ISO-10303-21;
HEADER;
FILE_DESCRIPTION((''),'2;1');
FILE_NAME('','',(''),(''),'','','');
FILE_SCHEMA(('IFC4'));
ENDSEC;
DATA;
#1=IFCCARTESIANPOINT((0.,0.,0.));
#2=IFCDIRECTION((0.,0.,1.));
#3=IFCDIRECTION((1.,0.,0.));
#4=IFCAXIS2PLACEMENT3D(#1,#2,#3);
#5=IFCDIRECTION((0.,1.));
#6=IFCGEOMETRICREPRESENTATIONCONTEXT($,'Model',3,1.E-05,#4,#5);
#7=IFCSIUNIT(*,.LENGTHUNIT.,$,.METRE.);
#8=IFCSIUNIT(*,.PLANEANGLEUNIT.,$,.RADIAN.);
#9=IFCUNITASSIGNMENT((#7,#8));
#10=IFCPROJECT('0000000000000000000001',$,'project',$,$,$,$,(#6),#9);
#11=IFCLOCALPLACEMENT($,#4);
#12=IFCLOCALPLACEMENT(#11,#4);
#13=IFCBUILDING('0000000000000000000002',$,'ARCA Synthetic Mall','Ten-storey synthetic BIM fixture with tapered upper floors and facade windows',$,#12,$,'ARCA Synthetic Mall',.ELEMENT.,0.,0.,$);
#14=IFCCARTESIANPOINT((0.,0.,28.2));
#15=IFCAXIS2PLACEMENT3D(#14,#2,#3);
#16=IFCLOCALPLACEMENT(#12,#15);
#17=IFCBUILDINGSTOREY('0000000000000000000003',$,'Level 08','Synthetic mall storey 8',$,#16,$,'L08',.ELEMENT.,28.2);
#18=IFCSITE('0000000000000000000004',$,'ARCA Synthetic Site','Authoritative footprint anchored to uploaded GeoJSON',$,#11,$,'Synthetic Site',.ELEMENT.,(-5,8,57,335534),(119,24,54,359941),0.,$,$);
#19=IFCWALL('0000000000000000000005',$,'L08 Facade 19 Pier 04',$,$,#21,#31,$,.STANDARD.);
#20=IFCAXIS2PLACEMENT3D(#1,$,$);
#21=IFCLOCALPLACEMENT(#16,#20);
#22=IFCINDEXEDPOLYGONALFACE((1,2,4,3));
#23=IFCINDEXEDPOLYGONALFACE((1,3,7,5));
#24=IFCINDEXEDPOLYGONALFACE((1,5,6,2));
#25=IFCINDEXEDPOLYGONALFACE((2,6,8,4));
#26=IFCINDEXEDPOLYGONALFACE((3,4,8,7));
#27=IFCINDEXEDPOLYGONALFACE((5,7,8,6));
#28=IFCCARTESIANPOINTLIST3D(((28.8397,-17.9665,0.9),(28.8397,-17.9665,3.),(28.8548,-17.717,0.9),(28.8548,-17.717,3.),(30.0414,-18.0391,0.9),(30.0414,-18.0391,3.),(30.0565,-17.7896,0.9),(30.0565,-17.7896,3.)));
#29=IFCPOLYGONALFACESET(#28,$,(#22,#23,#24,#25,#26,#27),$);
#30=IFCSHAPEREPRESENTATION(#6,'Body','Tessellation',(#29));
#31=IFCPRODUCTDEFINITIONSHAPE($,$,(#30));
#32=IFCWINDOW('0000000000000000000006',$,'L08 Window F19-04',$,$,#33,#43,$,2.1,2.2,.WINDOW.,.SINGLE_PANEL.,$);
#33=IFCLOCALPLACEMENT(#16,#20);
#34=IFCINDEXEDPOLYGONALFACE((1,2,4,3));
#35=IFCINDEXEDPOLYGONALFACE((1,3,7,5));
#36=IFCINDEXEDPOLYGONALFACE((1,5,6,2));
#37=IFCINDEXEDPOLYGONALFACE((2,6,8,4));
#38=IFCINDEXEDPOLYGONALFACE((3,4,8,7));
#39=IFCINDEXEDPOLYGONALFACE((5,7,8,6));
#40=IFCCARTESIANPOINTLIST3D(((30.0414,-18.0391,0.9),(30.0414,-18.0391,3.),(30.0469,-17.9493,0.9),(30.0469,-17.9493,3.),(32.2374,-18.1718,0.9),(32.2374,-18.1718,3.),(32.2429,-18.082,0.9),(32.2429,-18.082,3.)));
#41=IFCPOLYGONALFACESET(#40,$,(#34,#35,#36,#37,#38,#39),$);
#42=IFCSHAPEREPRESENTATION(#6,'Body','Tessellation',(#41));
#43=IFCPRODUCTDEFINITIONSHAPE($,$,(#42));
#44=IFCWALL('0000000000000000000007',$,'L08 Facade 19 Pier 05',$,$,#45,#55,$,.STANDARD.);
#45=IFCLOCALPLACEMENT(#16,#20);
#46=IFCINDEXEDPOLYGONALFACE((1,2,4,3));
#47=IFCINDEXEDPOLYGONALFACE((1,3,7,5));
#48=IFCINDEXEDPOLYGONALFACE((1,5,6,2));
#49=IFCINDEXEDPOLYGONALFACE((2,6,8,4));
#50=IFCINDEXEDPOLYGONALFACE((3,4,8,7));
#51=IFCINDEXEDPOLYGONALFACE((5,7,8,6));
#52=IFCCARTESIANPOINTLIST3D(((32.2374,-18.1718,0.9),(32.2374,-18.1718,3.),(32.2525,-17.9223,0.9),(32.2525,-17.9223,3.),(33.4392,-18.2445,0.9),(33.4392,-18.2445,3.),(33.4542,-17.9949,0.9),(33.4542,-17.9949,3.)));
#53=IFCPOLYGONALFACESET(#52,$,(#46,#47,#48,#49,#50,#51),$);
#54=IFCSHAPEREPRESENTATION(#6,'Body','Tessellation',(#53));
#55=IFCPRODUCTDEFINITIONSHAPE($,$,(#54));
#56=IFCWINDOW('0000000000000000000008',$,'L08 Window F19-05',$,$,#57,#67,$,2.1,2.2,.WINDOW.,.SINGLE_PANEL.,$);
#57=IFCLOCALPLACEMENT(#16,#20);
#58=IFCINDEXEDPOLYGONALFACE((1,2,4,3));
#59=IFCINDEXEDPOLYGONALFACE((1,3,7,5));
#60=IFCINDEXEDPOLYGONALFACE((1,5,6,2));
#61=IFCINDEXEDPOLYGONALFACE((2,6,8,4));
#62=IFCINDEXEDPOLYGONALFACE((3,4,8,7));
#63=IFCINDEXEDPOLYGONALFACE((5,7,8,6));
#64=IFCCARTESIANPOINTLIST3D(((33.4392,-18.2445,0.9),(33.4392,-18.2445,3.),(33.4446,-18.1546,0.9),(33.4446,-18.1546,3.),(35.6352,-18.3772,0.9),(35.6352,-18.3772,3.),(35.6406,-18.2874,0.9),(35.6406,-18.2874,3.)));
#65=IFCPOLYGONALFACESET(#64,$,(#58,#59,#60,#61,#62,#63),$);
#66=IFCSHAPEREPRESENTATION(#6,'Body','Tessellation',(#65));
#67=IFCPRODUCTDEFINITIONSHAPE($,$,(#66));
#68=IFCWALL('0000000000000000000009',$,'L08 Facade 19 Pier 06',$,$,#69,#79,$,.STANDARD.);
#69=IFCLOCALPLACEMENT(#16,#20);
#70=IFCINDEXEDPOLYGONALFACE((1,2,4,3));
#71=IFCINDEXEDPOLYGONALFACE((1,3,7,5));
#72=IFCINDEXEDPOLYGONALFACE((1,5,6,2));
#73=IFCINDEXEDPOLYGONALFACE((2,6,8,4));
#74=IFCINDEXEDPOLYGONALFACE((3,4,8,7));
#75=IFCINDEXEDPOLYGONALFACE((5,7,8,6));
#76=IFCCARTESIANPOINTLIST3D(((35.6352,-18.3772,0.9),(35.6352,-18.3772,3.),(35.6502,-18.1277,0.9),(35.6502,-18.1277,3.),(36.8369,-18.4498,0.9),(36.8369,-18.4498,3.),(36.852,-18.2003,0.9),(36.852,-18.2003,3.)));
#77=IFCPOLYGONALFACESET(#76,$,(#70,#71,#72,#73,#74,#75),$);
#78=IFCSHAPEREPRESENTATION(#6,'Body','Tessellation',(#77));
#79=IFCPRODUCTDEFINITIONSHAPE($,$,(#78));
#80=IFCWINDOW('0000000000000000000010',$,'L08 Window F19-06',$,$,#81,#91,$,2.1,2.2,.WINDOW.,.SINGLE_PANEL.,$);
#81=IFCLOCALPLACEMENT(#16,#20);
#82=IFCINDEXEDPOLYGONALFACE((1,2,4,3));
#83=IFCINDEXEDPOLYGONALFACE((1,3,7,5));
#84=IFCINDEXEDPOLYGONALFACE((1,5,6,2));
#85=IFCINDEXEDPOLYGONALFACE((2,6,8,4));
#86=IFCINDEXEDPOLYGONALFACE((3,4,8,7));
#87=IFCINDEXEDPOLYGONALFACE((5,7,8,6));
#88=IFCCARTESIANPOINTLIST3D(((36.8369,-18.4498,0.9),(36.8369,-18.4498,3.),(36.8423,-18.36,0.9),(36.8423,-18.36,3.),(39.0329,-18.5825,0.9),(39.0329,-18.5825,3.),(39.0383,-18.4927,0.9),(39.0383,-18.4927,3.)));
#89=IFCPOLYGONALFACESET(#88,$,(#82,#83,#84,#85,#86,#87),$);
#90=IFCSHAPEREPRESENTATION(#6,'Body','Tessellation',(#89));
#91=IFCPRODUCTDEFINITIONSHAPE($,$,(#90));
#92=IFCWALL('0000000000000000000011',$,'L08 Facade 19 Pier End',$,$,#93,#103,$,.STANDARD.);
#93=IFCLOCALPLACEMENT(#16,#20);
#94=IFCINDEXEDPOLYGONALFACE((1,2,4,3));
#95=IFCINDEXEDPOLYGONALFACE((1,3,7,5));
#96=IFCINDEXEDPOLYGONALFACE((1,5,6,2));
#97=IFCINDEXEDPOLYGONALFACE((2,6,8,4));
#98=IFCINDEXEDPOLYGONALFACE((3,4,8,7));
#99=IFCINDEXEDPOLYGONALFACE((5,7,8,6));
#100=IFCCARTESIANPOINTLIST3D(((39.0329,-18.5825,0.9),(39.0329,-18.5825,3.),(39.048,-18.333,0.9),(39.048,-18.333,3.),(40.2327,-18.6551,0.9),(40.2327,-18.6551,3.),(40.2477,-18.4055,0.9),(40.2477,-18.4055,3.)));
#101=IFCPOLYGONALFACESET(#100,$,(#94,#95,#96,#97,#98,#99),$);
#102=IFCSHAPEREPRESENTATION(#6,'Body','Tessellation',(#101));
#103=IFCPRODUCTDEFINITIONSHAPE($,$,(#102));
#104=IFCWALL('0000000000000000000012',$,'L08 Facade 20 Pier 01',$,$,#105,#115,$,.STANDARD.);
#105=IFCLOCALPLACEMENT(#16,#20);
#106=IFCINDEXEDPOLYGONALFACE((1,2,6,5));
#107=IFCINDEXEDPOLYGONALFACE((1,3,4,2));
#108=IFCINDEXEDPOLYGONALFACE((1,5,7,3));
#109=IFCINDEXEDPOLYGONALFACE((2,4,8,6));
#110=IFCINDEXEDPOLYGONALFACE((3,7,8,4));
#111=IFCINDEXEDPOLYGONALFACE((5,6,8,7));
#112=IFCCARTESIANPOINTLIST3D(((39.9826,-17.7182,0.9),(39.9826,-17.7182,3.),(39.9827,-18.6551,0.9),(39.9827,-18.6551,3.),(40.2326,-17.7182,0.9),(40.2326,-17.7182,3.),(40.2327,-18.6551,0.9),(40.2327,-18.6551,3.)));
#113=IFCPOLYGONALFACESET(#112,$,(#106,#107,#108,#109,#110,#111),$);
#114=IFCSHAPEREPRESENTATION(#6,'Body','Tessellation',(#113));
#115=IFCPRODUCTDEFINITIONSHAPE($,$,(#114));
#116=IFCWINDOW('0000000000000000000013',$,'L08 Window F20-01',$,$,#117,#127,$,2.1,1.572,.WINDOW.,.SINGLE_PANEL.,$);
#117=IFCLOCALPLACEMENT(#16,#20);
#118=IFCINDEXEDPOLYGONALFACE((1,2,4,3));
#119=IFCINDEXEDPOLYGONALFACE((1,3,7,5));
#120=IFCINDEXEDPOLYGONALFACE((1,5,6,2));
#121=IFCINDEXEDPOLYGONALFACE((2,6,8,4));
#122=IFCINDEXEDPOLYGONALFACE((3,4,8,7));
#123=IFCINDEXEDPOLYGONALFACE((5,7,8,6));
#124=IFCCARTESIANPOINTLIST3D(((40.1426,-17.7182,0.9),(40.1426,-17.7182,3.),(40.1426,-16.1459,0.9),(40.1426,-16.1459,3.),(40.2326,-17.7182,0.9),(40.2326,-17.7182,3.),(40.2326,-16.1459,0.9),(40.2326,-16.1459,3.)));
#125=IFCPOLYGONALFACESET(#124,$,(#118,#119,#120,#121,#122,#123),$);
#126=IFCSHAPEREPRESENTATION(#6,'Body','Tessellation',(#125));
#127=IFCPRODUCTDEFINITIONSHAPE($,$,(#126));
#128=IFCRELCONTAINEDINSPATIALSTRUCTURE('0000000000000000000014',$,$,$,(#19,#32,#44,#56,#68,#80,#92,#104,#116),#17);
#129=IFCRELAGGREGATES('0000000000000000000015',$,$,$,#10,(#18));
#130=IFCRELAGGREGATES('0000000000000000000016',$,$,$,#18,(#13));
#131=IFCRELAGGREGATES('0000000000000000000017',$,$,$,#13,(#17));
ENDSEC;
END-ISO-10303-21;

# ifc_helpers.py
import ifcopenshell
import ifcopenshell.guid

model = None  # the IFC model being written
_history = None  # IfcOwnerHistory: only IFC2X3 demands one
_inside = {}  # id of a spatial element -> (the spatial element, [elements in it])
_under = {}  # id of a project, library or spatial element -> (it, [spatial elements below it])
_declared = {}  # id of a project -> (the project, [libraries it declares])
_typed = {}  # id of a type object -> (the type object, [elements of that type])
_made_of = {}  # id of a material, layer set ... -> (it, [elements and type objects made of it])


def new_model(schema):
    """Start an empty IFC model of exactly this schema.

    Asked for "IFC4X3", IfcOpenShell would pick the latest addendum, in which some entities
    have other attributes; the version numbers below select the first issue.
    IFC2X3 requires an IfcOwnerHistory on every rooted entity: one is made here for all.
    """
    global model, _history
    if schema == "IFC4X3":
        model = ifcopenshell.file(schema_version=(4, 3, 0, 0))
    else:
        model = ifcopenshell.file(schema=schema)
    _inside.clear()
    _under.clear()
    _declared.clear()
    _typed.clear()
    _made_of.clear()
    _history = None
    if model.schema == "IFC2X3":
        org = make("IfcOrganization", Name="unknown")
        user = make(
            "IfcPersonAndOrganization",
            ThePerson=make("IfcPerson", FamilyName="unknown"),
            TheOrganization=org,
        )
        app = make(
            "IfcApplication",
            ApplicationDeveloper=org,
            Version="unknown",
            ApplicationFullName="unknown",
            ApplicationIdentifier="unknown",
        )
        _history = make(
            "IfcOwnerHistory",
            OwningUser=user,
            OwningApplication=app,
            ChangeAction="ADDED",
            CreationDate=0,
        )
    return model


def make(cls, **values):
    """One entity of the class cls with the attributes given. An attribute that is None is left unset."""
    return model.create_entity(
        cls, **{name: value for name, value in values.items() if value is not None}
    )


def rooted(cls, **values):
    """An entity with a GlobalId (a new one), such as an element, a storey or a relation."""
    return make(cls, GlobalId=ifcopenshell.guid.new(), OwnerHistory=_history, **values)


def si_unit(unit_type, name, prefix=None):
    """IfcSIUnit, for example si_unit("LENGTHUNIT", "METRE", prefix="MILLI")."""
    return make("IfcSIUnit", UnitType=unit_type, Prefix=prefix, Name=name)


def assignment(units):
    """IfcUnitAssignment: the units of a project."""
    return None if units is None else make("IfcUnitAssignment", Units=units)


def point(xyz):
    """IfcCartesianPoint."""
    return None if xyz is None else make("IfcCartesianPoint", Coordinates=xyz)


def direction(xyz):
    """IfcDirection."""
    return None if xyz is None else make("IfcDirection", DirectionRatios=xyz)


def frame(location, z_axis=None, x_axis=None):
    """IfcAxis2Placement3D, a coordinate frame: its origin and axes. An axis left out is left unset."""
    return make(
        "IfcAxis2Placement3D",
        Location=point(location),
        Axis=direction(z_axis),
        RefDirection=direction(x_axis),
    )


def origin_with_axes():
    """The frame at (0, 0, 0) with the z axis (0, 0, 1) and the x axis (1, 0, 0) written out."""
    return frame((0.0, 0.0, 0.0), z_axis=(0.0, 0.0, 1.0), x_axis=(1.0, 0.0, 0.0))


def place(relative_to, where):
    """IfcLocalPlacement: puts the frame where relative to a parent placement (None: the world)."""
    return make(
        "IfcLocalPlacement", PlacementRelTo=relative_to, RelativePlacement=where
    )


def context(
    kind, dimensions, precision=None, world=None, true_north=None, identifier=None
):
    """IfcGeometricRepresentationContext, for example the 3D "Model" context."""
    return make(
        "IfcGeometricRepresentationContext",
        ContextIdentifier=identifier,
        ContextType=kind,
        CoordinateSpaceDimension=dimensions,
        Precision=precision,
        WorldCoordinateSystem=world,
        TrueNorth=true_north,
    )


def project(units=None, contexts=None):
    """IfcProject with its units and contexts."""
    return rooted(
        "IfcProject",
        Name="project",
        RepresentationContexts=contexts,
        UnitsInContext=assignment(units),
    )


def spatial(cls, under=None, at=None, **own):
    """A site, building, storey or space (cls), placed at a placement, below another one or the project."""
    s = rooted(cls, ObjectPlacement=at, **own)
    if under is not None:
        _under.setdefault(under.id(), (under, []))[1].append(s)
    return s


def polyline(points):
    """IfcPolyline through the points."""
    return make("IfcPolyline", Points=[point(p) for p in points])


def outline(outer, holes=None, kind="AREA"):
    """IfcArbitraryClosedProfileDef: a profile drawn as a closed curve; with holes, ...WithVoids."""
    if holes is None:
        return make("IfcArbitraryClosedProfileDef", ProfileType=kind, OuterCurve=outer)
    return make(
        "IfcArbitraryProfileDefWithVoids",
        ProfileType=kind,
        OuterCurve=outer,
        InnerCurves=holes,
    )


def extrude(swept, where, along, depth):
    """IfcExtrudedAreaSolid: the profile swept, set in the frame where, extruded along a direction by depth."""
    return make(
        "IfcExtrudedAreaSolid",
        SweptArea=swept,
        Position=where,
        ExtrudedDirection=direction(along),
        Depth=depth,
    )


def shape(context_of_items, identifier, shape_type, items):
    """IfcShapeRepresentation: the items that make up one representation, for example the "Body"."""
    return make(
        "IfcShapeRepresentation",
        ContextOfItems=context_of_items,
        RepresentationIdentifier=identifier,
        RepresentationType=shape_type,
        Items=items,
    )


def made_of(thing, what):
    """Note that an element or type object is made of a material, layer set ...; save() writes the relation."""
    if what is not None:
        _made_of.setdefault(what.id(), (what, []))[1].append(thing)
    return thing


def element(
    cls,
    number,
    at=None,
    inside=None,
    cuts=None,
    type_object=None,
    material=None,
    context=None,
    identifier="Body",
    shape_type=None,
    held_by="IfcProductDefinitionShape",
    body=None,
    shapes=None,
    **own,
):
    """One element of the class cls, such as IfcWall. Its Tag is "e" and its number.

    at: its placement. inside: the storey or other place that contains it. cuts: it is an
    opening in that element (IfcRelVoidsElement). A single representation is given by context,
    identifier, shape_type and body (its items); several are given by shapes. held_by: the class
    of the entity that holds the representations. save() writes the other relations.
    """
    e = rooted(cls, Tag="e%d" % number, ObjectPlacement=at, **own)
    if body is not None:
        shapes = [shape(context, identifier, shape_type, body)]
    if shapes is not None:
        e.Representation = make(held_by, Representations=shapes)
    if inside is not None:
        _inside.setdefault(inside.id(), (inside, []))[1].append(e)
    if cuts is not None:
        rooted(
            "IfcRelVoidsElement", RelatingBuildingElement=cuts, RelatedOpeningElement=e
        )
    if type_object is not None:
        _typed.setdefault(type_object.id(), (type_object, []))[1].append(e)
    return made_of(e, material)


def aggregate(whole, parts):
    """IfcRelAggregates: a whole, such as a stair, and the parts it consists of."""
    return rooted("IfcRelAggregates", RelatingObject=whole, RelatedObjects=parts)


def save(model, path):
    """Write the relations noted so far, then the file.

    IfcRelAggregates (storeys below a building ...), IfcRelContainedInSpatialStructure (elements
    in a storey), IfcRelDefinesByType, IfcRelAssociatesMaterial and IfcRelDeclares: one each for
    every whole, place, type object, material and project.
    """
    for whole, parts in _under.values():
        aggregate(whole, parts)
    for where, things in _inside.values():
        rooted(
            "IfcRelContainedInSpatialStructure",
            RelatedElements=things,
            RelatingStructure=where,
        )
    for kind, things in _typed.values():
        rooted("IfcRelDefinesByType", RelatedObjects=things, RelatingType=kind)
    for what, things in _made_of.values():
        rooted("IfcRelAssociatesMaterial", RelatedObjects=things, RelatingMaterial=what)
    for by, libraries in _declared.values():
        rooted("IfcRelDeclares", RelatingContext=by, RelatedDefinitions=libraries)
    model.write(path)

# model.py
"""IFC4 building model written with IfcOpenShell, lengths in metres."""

from ifc_helpers import new_model, si_unit, direction, frame, origin_with_axes, place, context, project, spatial, polyline, outline, extrude, element, save


model = new_model("IFC4")

# Units and contexts
model_context = context("Model", 3, precision=1e-05, world=origin_with_axes(), true_north=direction((0.0, 1.0)))
ifc_project = project(units=[si_unit("LENGTHUNIT", "METRE"), si_unit("PLANEANGLEUNIT", "RADIAN")], contexts=[model_context])

# Site, building, storey
site_placement = place(None, origin_with_axes())
site = spatial("IfcSite", under=ifc_project, at=site_placement, Name="ARCA Synthetic Site", Description="Authoritative footprint anchored to uploaded GeoJSON", LongName="Synthetic Site", CompositionType="ELEMENT", RefLatitude=(-5, 8, 57, 335534), RefLongitude=(119, 24, 54, 359941), RefElevation=0.0)
building_placement = place(site_placement, origin_with_axes())
building = spatial("IfcBuilding", under=site, at=building_placement, Name="ARCA Synthetic Mall", Description="Ten-storey synthetic BIM fixture with tapered upper floors and facade windows", LongName="ARCA Synthetic Mall", CompositionType="ELEMENT", ElevationOfRefHeight=0.0, ElevationOfTerrain=0.0)
storey_placement = place(building_placement, frame((0.0, 0.0, 28.2), z_axis=(0.0, 0.0, 1.0), x_axis=(1.0, 0.0, 0.0)))
storey = spatial("IfcBuildingStorey", under=building, at=storey_placement, Name="Level 08", Description="Synthetic mall storey 8", LongName="L08", CompositionType="ELEMENT", Elevation=28.2)

# Wall
wall_1_placement = place(storey_placement, frame((0.0, 0.0, 0.9), z_axis=(0.0, 0.0, 1.0), x_axis=(1.0, 0.0, 0.0)))
element("IfcWall", 1, at=wall_1_placement, inside=storey, Name="L08 Facade 19 Pier 04", PredefinedType="STANDARD", context=model_context, shape_type="SweptSolid", body=[
    extrude(outline(polyline([(28.8397, -17.9665), (30.0414, -18.0391), (30.0565, -17.7896), (28.8548, -17.717), (28.8397, -17.9665)])), origin_with_axes(), (0.0, 0.0, 1.0), 2.1),
])

# Window
window_1_placement = place(storey_placement, frame((0.0, 0.0, 0.9), z_axis=(0.0, 0.0, 1.0), x_axis=(1.0, 0.0, 0.0)))
element("IfcWindow", 2, at=window_1_placement, inside=storey, Name="L08 Window F19-04", OverallHeight=2.1, OverallWidth=2.2, PartitioningType="SINGLE_PANEL", PredefinedType="WINDOW", context=model_context, shape_type="SweptSolid", body=[
    extrude(outline(polyline([(30.0414, -18.0391), (32.2374, -18.1718), (32.2429, -18.082), (30.0469, -17.9493), (30.0414, -18.0391)])), origin_with_axes(), (0.0, 0.0, 1.0), 2.1),
])

# Wall
wall_2_placement = place(storey_placement, frame((0.0, 0.0, 0.9), z_axis=(0.0, 0.0, 1.0), x_axis=(1.0, 0.0, 0.0)))
element("IfcWall", 3, at=wall_2_placement, inside=storey, Name="L08 Facade 19 Pier 05", PredefinedType="STANDARD", context=model_context, shape_type="SweptSolid", body=[
    extrude(outline(polyline([(32.2374, -18.1718), (33.4392, -18.2445), (33.4542, -17.9949), (32.2525, -17.9223), (32.2374, -18.1718)])), origin_with_axes(), (0.0, 0.0, 1.0), 2.1),
])

# Window
window_2_placement = place(storey_placement, frame((0.0, 0.0, 0.9), z_axis=(0.0, 0.0, 1.0), x_axis=(1.0, 0.0, 0.0)))
element("IfcWindow", 4, at=window_2_placement, inside=storey, Name="L08 Window F19-05", OverallHeight=2.1, OverallWidth=2.2, PartitioningType="SINGLE_PANEL", PredefinedType="WINDOW", context=model_context, shape_type="SweptSolid", body=[
    extrude(outline(polyline([(33.4392, -18.2445), (35.6352, -18.3772), (35.6406, -18.2874), (33.4446, -18.1546), (33.4392, -18.2445)])), origin_with_axes(), (0.0, 0.0, 1.0), 2.1),
])

# Wall
wall_3_placement = place(storey_placement, frame((0.0, 0.0, 0.9), z_axis=(0.0, 0.0, 1.0), x_axis=(1.0, 0.0, 0.0)))
element("IfcWall", 5, at=wall_3_placement, inside=storey, Name="L08 Facade 19 Pier 06", PredefinedType="STANDARD", context=model_context, shape_type="SweptSolid", body=[
    extrude(outline(polyline([(35.6352, -18.3772), (36.8369, -18.4498), (36.852, -18.2003), (35.6502, -18.1277), (35.6352, -18.3772)])), origin_with_axes(), (0.0, 0.0, 1.0), 2.1),
])

# Window
window_3_placement = place(storey_placement, frame((0.0, 0.0, 0.9), z_axis=(0.0, 0.0, 1.0), x_axis=(1.0, 0.0, 0.0)))
element("IfcWindow", 6, at=window_3_placement, inside=storey, Name="L08 Window F19-06", OverallHeight=2.1, OverallWidth=2.2, PartitioningType="SINGLE_PANEL", PredefinedType="WINDOW", context=model_context, shape_type="SweptSolid", body=[
    extrude(outline(polyline([(36.8369, -18.4498), (39.0329, -18.5825), (39.0383, -18.4927), (36.8423, -18.36), (36.8369, -18.4498)])), origin_with_axes(), (0.0, 0.0, 1.0), 2.1),
])

# Walls
wall_4_placement = place(storey_placement, frame((0.0, 0.0, 0.9), z_axis=(0.0, 0.0, 1.0), x_axis=(1.0, 0.0, 0.0)))
element("IfcWall", 7, at=wall_4_placement, inside=storey, Name="L08 Facade 19 Pier End", PredefinedType="STANDARD", context=model_context, shape_type="SweptSolid", body=[
    extrude(outline(polyline([(39.0329, -18.5825), (40.2327, -18.6551), (40.2477, -18.4055), (39.048, -18.333), (39.0329, -18.5825)])), origin_with_axes(), (0.0, 0.0, 1.0), 2.1),
])
wall_5_placement = place(storey_placement, frame((0.0, 0.0, 0.9), z_axis=(0.0, 0.0, 1.0), x_axis=(1.0, 0.0, 0.0)))
element("IfcWall", 8, at=wall_5_placement, inside=storey, Name="L08 Facade 20 Pier 01", PredefinedType="STANDARD", context=model_context, shape_type="SweptSolid", body=[
    extrude(outline(polyline([(40.2327, -18.6551), (40.2326, -17.7182), (39.9826, -17.7182), (39.9827, -18.6551), (40.2327, -18.6551)])), origin_with_axes(), (0.0, 0.0, 1.0), 2.1),
])

# Window
window_4_placement = place(storey_placement, frame((0.0, 0.0, 0.9), z_axis=(0.0, 0.0, 1.0), x_axis=(1.0, 0.0, 0.0)))
element("IfcWindow", 9, at=window_4_placement, inside=storey, Name="L08 Window F20-01", OverallHeight=2.1, OverallWidth=1.572, PartitioningType="SINGLE_PANEL", PredefinedType="WINDOW", context=model_context, shape_type="SweptSolid", body=[
    extrude(outline(polyline([(40.2326, -17.7182), (40.2326, -16.1459), (40.1426, -16.1459), (40.1426, -17.7182), (40.2326, -17.7182)])), origin_with_axes(), (0.0, 0.0, 1.0), 2.1),
])

save(model, "model.ifc")
